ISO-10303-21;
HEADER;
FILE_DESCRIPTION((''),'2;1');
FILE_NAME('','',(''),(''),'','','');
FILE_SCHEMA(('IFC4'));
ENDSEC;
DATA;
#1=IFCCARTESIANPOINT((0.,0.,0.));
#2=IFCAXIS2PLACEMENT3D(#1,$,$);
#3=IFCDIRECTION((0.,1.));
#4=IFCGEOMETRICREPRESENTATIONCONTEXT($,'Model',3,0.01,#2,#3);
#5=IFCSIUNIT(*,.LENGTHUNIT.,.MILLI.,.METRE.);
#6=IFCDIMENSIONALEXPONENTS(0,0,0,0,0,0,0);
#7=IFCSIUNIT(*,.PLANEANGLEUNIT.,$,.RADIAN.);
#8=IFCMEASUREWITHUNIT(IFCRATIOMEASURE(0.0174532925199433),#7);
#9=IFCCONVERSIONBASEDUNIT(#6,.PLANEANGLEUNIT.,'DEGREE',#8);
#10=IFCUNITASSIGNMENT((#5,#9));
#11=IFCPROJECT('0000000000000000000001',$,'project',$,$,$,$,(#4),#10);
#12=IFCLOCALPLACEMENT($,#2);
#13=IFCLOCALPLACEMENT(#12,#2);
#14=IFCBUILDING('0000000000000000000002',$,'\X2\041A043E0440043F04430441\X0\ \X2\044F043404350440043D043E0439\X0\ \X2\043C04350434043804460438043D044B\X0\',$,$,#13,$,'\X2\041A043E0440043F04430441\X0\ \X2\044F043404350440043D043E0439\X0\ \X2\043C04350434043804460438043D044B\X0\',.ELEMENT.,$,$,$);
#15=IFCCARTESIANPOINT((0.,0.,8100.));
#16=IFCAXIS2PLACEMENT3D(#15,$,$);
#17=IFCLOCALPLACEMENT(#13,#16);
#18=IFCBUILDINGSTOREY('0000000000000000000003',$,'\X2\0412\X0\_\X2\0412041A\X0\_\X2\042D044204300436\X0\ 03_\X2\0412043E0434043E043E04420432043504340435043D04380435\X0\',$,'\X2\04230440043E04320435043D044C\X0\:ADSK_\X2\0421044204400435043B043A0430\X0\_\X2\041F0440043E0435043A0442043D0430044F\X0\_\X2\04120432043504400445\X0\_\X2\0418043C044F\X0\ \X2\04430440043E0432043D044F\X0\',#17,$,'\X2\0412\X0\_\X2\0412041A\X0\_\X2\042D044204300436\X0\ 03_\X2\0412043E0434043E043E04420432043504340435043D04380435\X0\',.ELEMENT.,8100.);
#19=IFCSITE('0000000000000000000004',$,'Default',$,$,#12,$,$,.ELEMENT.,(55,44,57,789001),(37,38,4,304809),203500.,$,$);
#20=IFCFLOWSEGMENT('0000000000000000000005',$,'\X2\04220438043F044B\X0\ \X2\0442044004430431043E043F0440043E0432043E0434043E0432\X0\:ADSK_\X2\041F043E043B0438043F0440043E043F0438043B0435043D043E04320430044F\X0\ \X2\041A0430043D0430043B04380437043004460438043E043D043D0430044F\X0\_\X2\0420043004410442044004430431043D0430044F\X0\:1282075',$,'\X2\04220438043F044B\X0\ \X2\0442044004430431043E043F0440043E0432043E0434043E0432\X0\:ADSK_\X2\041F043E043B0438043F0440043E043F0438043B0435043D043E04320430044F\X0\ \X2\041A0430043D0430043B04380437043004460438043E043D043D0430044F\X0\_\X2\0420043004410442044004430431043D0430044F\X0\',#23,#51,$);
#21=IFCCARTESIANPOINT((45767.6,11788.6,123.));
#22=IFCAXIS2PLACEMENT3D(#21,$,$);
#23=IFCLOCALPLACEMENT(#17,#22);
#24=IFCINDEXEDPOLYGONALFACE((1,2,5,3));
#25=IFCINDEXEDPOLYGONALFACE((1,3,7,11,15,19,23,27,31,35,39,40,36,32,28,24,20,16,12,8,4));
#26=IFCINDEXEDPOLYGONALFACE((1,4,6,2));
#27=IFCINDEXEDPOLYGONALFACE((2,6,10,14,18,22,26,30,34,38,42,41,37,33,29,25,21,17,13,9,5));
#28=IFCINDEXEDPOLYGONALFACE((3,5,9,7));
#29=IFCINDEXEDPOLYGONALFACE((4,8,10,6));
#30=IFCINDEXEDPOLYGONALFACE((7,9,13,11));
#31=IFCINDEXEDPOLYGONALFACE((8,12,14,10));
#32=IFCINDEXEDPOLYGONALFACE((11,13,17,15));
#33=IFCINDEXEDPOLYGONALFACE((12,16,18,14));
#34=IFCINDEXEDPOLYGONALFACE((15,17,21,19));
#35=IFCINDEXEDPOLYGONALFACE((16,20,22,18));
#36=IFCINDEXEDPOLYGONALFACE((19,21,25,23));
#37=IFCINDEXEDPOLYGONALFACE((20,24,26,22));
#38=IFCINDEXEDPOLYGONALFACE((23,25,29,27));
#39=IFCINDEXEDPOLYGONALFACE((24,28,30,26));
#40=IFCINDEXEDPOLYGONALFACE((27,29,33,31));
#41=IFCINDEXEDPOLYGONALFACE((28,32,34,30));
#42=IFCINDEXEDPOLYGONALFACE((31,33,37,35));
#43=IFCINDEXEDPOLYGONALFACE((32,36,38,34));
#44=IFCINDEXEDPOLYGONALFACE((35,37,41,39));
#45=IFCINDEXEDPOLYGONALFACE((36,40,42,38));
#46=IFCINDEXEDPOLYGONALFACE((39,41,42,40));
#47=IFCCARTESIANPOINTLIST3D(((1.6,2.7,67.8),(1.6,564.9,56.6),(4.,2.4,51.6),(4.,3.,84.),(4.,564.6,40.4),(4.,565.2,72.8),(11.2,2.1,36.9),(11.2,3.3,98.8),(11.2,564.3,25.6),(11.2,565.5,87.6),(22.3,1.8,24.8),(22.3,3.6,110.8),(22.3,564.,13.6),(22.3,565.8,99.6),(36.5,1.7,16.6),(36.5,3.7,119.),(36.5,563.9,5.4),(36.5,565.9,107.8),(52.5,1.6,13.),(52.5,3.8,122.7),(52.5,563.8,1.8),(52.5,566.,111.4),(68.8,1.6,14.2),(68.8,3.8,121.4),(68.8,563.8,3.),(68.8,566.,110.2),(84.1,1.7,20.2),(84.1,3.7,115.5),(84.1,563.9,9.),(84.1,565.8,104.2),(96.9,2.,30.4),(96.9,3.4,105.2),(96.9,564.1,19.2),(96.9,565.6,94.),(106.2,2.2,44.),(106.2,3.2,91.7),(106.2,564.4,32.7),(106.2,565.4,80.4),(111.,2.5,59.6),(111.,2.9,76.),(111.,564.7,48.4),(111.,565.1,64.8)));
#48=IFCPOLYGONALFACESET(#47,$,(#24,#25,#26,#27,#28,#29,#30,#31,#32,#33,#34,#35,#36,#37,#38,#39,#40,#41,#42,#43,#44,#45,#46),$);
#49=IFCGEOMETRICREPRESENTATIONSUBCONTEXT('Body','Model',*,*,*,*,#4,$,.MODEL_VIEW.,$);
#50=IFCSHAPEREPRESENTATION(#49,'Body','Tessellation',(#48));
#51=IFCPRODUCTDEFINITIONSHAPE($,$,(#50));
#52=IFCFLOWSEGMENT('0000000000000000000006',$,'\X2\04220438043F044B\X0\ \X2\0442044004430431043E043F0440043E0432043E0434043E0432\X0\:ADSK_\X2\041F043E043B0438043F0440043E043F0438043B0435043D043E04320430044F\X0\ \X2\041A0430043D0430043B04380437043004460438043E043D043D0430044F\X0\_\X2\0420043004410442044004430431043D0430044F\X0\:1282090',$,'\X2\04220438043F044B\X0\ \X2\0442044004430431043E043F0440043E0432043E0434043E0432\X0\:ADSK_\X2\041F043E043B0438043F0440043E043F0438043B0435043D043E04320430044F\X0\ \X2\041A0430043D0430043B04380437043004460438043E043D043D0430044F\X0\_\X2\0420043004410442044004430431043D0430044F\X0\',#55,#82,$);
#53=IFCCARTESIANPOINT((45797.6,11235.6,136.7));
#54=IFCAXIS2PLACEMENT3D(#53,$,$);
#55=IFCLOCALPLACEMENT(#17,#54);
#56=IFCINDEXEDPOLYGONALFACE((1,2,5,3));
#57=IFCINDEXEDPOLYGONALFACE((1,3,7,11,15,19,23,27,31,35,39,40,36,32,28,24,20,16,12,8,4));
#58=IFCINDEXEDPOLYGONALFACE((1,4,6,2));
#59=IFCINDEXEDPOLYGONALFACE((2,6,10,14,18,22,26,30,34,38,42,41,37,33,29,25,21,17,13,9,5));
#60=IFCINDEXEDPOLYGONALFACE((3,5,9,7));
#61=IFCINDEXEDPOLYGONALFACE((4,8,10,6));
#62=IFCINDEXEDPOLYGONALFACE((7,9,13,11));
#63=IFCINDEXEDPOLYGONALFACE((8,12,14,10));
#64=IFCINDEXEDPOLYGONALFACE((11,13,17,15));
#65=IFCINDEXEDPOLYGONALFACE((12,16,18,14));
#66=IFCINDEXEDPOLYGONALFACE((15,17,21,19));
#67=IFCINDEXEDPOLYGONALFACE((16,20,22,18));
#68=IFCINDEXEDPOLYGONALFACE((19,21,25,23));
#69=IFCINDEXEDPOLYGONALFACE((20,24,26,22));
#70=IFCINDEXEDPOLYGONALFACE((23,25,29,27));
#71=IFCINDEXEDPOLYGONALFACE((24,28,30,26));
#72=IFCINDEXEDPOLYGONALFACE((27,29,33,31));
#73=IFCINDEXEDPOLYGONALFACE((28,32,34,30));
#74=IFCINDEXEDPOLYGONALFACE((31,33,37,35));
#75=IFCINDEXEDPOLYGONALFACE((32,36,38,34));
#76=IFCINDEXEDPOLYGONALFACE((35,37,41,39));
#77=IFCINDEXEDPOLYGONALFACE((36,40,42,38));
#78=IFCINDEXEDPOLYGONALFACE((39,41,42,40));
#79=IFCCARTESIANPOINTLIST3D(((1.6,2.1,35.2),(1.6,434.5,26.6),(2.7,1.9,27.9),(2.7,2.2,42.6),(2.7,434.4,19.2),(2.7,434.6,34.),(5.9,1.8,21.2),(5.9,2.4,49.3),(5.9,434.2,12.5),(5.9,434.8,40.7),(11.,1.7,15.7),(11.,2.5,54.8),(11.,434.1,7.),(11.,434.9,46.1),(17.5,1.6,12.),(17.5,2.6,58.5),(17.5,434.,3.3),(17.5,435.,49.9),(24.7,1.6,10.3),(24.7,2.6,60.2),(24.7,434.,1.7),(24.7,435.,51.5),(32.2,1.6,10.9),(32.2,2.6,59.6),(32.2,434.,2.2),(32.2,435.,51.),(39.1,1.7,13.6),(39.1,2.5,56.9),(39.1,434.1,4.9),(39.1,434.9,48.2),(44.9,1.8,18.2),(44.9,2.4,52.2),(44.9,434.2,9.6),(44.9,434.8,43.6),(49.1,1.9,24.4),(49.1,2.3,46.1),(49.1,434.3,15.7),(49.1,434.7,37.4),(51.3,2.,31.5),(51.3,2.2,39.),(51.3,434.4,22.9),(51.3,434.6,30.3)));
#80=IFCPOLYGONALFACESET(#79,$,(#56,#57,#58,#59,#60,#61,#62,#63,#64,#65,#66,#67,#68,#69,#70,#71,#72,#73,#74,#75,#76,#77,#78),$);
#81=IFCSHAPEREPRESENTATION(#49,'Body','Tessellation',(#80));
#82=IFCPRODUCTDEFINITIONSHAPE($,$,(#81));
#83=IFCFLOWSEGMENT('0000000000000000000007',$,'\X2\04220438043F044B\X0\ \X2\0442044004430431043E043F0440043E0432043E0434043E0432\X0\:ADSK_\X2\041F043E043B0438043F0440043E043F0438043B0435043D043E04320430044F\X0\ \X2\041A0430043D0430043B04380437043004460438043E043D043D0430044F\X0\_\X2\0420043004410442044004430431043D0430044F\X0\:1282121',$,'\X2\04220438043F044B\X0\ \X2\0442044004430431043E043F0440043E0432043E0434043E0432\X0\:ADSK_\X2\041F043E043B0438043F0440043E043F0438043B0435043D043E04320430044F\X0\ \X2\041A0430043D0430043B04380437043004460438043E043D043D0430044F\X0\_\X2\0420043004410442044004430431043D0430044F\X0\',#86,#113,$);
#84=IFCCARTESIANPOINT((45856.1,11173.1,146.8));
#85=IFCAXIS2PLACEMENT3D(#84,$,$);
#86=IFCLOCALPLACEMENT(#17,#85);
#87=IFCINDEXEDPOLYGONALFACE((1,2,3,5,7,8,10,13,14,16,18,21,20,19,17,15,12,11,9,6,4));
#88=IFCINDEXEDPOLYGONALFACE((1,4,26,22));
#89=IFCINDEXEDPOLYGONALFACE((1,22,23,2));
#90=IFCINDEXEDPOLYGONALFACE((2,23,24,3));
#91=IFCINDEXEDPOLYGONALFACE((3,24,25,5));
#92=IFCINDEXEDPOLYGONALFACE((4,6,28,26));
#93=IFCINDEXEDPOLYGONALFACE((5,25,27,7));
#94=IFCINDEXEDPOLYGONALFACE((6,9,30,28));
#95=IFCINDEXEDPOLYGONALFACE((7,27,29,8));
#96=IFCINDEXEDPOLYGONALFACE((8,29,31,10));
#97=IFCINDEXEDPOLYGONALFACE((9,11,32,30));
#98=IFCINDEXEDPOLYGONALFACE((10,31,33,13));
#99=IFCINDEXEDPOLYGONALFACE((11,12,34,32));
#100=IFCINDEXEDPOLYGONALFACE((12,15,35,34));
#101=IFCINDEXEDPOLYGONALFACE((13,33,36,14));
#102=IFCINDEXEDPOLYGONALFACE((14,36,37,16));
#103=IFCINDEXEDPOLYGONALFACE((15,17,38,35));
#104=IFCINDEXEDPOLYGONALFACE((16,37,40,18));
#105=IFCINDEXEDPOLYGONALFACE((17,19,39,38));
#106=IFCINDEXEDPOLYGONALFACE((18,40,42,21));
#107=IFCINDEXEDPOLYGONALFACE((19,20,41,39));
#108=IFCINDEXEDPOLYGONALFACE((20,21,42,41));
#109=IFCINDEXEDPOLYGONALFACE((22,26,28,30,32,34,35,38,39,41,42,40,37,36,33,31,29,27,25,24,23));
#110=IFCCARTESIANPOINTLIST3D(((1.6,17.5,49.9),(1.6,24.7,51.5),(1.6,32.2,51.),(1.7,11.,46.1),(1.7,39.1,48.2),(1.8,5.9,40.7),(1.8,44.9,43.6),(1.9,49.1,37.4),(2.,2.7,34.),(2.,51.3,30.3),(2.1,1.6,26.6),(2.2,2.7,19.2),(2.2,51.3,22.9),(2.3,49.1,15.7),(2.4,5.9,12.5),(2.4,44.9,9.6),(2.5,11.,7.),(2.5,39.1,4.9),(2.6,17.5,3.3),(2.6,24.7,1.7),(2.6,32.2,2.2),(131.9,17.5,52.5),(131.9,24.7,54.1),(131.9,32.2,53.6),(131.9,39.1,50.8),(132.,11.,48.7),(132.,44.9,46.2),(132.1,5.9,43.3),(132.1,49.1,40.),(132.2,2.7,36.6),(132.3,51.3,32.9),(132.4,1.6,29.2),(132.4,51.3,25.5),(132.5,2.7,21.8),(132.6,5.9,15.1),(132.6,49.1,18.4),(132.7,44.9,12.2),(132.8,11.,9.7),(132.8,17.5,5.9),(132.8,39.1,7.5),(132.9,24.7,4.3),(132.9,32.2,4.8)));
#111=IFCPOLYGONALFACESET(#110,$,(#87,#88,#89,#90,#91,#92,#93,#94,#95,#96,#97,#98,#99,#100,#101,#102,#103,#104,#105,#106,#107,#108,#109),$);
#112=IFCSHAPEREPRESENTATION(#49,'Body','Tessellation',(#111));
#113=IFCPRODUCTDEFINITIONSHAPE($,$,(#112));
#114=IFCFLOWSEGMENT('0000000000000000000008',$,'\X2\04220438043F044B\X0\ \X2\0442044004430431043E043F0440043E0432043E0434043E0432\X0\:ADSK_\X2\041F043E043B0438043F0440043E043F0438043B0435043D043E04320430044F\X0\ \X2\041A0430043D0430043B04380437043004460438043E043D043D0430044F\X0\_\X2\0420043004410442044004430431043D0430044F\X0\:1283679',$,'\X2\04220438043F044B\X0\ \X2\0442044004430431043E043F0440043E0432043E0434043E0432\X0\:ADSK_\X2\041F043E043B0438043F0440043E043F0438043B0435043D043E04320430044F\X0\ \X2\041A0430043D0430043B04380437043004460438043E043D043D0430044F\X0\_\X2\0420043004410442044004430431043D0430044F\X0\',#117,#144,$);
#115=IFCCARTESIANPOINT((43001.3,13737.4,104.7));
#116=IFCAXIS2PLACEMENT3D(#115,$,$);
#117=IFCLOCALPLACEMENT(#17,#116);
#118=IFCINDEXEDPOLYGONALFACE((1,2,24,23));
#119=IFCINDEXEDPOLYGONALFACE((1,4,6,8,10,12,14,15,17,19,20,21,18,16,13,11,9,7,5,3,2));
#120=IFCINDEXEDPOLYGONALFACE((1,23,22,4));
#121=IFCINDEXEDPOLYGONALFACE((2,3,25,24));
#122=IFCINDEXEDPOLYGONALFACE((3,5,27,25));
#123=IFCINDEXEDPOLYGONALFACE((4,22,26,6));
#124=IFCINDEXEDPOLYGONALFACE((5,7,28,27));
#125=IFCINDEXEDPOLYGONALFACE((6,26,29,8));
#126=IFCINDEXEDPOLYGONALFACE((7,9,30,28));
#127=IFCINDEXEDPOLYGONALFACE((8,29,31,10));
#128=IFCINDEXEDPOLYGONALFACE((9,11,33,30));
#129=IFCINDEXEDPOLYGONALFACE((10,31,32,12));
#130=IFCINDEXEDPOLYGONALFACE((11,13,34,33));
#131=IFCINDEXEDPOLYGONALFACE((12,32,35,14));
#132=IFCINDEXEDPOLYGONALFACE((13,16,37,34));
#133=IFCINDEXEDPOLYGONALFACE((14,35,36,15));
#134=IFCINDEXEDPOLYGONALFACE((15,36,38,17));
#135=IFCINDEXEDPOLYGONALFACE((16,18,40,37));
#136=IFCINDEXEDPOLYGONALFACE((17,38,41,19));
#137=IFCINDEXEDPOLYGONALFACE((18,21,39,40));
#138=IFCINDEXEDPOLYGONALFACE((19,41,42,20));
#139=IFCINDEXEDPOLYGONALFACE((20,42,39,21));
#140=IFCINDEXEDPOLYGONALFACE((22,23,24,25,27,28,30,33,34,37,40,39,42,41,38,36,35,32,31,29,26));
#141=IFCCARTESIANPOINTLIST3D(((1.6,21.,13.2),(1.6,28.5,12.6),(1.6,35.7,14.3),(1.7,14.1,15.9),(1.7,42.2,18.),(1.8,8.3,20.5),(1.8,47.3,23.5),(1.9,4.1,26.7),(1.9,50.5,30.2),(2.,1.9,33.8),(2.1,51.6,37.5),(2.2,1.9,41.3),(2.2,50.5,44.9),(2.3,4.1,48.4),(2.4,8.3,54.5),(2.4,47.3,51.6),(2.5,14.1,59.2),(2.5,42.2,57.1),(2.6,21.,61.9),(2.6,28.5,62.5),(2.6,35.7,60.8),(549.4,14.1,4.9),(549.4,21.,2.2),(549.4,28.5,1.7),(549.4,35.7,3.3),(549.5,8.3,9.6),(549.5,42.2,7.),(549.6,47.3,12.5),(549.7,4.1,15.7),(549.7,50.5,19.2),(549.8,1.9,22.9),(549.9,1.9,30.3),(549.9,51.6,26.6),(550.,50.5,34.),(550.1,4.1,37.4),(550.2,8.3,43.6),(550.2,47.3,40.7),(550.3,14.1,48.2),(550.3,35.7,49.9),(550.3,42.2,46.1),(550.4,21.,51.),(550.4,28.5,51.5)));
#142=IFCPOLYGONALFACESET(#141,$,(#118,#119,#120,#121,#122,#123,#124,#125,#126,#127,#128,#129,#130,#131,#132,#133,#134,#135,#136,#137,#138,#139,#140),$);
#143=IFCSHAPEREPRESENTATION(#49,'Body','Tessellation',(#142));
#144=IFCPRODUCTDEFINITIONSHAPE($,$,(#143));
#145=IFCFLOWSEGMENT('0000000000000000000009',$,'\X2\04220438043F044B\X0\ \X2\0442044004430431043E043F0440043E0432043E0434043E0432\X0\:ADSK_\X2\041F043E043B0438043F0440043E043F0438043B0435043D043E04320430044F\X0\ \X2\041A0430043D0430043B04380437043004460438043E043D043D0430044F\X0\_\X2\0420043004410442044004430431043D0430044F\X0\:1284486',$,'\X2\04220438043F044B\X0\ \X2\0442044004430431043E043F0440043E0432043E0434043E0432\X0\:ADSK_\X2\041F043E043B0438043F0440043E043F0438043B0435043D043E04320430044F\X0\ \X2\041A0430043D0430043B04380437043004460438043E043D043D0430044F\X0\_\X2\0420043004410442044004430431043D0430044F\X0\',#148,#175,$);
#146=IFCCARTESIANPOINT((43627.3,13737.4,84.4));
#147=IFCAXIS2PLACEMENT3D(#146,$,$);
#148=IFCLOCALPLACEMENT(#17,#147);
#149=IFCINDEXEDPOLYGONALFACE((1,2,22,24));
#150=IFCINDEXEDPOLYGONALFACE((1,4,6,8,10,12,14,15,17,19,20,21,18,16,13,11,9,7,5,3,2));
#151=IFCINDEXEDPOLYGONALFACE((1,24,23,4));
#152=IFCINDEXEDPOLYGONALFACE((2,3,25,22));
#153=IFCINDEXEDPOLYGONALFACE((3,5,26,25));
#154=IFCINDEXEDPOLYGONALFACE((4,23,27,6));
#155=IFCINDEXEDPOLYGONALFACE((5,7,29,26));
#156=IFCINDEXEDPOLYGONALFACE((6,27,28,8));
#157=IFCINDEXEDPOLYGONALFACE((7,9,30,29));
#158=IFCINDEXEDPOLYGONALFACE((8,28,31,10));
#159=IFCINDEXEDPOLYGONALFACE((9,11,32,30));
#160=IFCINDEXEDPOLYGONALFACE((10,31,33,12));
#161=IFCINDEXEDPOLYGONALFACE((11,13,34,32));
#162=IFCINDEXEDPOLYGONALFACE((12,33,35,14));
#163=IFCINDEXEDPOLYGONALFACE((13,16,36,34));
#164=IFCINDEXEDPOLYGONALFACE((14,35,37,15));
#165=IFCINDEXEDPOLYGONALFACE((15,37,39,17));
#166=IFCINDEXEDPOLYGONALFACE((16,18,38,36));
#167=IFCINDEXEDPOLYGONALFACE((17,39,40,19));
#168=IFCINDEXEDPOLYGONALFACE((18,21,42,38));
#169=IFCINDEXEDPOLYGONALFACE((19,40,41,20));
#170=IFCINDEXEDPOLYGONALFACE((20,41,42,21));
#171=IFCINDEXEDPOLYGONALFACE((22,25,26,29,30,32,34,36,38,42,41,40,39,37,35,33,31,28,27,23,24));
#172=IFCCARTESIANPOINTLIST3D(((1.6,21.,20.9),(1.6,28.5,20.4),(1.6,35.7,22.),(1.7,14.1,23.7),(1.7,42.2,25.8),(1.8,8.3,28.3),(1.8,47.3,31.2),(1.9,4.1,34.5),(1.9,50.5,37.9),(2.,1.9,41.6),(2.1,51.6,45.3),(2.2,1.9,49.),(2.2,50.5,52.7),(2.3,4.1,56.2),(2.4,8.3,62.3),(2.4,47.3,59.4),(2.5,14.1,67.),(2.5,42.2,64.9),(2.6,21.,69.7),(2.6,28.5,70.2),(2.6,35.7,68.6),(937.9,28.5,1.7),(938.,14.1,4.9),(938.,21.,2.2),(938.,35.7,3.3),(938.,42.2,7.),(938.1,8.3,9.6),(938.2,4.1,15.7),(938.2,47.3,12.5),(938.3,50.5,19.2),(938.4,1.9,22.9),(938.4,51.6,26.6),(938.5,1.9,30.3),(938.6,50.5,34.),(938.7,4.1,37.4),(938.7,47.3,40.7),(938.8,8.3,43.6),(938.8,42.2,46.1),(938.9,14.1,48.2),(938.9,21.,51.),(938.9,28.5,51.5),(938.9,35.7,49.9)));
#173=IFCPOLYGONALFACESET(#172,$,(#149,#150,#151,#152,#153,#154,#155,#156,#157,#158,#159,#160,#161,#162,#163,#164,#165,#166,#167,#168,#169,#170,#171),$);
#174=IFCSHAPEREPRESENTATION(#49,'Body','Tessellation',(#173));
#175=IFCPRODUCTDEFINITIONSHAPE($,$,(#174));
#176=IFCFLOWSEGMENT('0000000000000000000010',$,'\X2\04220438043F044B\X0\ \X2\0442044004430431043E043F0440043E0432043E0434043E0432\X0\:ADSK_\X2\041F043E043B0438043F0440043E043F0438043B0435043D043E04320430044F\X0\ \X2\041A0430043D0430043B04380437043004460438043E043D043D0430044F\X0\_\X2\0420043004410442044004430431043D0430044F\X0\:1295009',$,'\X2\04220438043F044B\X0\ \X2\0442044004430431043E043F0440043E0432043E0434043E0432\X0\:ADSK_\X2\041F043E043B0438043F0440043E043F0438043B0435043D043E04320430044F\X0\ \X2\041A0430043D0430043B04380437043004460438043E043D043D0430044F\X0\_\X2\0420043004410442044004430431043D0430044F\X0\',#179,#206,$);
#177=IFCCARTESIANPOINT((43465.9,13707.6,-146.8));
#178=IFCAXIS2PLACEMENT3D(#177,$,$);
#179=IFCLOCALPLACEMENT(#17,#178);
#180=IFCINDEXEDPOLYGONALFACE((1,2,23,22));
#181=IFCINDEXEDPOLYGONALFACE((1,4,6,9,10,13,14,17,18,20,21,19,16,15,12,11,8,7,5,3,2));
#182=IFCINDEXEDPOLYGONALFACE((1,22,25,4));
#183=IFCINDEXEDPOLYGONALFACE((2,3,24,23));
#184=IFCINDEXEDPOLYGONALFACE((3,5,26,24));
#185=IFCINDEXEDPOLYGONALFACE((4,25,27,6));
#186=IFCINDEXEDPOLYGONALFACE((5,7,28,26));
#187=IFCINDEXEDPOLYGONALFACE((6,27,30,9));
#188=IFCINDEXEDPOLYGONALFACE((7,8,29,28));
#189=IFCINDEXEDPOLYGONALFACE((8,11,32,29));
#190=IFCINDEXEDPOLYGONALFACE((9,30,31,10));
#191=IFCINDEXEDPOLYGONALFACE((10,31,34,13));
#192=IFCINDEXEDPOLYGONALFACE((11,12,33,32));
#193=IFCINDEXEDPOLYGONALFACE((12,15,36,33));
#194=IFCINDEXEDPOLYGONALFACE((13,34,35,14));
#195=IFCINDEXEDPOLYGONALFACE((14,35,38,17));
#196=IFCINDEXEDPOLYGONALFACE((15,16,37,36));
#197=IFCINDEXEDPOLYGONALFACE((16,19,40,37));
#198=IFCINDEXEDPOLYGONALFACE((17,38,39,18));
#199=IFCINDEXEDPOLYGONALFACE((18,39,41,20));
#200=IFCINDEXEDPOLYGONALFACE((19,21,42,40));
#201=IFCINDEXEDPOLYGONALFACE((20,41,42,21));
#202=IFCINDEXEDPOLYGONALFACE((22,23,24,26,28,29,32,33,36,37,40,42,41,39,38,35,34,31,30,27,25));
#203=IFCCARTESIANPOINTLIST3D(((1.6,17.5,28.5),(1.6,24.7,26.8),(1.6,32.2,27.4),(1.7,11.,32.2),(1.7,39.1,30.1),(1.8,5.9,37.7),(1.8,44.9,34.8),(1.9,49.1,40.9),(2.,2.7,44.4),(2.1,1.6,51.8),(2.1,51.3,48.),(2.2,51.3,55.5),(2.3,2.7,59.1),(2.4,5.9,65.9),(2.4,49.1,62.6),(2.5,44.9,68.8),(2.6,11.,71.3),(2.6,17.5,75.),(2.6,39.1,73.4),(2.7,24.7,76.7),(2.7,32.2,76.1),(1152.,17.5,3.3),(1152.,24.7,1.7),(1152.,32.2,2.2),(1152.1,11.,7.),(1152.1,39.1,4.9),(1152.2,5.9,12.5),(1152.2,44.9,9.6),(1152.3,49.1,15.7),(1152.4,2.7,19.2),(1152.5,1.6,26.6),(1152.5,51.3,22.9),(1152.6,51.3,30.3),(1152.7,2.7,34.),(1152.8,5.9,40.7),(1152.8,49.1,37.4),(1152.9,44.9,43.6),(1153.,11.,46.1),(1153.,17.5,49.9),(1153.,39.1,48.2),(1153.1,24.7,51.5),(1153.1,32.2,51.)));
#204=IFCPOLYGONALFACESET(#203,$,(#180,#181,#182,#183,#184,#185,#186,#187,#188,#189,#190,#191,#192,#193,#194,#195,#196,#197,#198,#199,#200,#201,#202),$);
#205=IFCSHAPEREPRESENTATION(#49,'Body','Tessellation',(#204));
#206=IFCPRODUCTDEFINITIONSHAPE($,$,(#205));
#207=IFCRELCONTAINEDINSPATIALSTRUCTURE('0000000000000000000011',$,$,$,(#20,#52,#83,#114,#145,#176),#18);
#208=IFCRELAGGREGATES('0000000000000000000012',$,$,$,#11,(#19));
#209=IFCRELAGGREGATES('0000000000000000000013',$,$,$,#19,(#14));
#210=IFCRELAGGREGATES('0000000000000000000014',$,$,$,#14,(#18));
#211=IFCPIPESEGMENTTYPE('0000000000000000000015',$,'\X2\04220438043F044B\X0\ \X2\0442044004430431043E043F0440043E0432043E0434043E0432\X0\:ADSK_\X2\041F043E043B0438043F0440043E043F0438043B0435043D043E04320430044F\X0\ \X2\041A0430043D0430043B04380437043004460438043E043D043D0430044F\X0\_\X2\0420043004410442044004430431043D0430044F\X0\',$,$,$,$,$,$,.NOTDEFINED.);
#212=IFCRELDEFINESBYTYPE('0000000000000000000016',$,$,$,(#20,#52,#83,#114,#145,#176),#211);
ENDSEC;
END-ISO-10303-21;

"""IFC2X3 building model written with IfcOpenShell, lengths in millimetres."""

from ifc_helpers import new_model, entity, si_unit, converted_unit, direction, frame, origin, origin_2d_with_axis, place, context, subcontext, project, spatial, circle, extrude, type_object, element, save


model = new_model("IFC2X3")

# Units and contexts
model_context = context("Model", 3, precision=0.01, world=origin(), true_north=direction((0.0, 1.0)))
body_context = subcontext(model_context, "Body", "Model", "MODEL_VIEW")
ifc_project = project(units=[si_unit("LENGTHUNIT", "METRE", prefix="MILLI"), converted_unit("PLANEANGLEUNIT", "DEGREE", entity("IfcRatioMeasure", 0.0174532925199433), si_unit("PLANEANGLEUNIT", "RADIAN"), dimensions=[0, 0, 0, 0, 0, 0, 0])], contexts=[model_context])

# Site, building, storey
site_placement = place(None, origin())
site = spatial("IfcSite", under=ifc_project, at=site_placement, Name="Default", CompositionType="ELEMENT", RefLatitude=(55, 44, 57, 789001), RefLongitude=(37, 38, 4, 304809), RefElevation=203500.0)
building_placement = place(site_placement, origin())
building = spatial("IfcBuilding", under=site, at=building_placement, Name="Корпус ядерной медицины", LongName="Корпус ядерной медицины", CompositionType="ELEMENT")
storey_placement = place(building_placement, frame((0.0, 0.0, 8100.0)))
storey = spatial("IfcBuildingStorey", under=building, at=storey_placement, Name="В_ВК_Этаж 03_Водоотведение", ObjectType="Уровень:ADSK_Стрелка_Проектная_Вверх_Имя уровня", LongName="В_ВК_Этаж 03_Водоотведение", CompositionType="ELEMENT", Elevation=8100.0)

# Flow segments
pipe_segment_type_1 = type_object("IfcPipeSegmentType", Name="Типы трубопроводов:ADSK_Полипропиленовая Канализационная_Раструбная", PredefinedType="NOTDEFINED")
flow_segment_1_placement = place(storey_placement, frame((45767.6, 11788.6, 123.0)))
element("IfcFlowSegment", 1, at=flow_segment_1_placement, inside=storey, type_object=pipe_segment_type_1, Name="Типы трубопроводов:ADSK_Полипропиленовая Канализационная_Раструбная:1282075", ObjectType="Типы трубопроводов:ADSK_Полипропиленовая Канализационная_Раструбная", context=body_context, shape_type="SweptSolid", body=[
    extrude(circle(Radius=55.0, at=origin_2d_with_axis()), frame((56.6, 2.7, 67.8), z_axis=(0.0, 0.9998, -0.019996), x_axis=(-1.0, 0.0, 0.0)), (0.0, 0.0, 1.0), 562.3),
])
flow_segment_2_placement = place(storey_placement, frame((45797.6, 11235.6, 136.7)))
element("IfcFlowSegment", 2, at=flow_segment_2_placement, inside=storey, type_object=pipe_segment_type_1, Name="Типы трубопроводов:ADSK_Полипропиленовая Канализационная_Раструбная:1282090", ObjectType="Типы трубопроводов:ADSK_Полипропиленовая Канализационная_Раструбная", context=body_context, shape_type="SweptSolid", body=[
    extrude(circle(Radius=25.0, at=origin_2d_with_axis()), frame((26.6, 434.5, 26.6), z_axis=(0.0, -0.9998, 0.019996), x_axis=(-1.0, 0.0, 0.0)), (0.0, 0.0, 1.0), 432.5),
])
flow_segment_3_placement = place(storey_placement, frame((45856.1, 11173.1, 146.8)))
element("IfcFlowSegment", 3, at=flow_segment_3_placement, inside=storey, type_object=pipe_segment_type_1, Name="Типы трубопроводов:ADSK_Полипропиленовая Канализационная_Раструбная:1282121", ObjectType="Типы трубопроводов:ADSK_Полипропиленовая Канализационная_Раструбная", context=body_context, shape_type="SweptSolid", body=[
    extrude(circle(Radius=25.0, at=origin_2d_with_axis()), frame((2.1, 26.6, 26.6), z_axis=(0.9998, 0.0, 0.019996), x_axis=(0.0, -1.0, 0.0)), (0.0, 0.0, 1.0), 130.3),
])
flow_segment_4_placement = place(storey_placement, frame((43001.3, 13737.4, 104.7)))
element("IfcFlowSegment", 4, at=flow_segment_4_placement, inside=storey, type_object=pipe_segment_type_1, Name="Типы трубопроводов:ADSK_Полипропиленовая Канализационная_Раструбная:1283679", ObjectType="Типы трубопроводов:ADSK_Полипропиленовая Канализационная_Раструбная", context=body_context, shape_type="SweptSolid", body=[
    extrude(circle(Radius=25.0, at=origin_2d_with_axis()), frame((549.9, 26.6, 26.6), z_axis=(-0.9998, 0.0, 0.019996), x_axis=(0.0, 1.0, 0.0)), (0.0, 0.0, 1.0), 547.9),
])
flow_segment_5_placement = place(storey_placement, frame((43627.3, 13737.4, 84.4)))
element("IfcFlowSegment", 5, at=flow_segment_5_placement, inside=storey, type_object=pipe_segment_type_1, Name="Типы трубопроводов:ADSK_Полипропиленовая Канализационная_Раструбная:1284486", ObjectType="Типы трубопроводов:ADSK_Полипропиленовая Канализационная_Раструбная", context=body_context, shape_type="SweptSolid", body=[
    extrude(circle(Radius=25.0, at=origin_2d_with_axis()), frame((938.4, 26.6, 26.6), z_axis=(-0.9998, 0.0, 0.019996), x_axis=(0.0, 1.0, 0.0)), (0.0, 0.0, 1.0), 936.5),
])
flow_segment_6_placement = place(storey_placement, frame((43465.9, 13707.6, -146.8)))
element("IfcFlowSegment", 6, at=flow_segment_6_placement, inside=storey, type_object=pipe_segment_type_1, Name="Типы трубопроводов:ADSK_Полипропиленовая Канализационная_Раструбная:1295009", ObjectType="Типы трубопроводов:ADSK_Полипропиленовая Канализационная_Раструбная", context=body_context, shape_type="SweptSolid", body=[
    extrude(circle(Radius=25.0, at=origin_2d_with_axis()), frame((1152.5, 26.6, 26.6), z_axis=(-0.99976, 0.0, 0.021885), x_axis=(0.0, -1.0, 0.0)), (0.0, 0.0, 1.0), 1150.7),
])

save(model, "model.ifc")
